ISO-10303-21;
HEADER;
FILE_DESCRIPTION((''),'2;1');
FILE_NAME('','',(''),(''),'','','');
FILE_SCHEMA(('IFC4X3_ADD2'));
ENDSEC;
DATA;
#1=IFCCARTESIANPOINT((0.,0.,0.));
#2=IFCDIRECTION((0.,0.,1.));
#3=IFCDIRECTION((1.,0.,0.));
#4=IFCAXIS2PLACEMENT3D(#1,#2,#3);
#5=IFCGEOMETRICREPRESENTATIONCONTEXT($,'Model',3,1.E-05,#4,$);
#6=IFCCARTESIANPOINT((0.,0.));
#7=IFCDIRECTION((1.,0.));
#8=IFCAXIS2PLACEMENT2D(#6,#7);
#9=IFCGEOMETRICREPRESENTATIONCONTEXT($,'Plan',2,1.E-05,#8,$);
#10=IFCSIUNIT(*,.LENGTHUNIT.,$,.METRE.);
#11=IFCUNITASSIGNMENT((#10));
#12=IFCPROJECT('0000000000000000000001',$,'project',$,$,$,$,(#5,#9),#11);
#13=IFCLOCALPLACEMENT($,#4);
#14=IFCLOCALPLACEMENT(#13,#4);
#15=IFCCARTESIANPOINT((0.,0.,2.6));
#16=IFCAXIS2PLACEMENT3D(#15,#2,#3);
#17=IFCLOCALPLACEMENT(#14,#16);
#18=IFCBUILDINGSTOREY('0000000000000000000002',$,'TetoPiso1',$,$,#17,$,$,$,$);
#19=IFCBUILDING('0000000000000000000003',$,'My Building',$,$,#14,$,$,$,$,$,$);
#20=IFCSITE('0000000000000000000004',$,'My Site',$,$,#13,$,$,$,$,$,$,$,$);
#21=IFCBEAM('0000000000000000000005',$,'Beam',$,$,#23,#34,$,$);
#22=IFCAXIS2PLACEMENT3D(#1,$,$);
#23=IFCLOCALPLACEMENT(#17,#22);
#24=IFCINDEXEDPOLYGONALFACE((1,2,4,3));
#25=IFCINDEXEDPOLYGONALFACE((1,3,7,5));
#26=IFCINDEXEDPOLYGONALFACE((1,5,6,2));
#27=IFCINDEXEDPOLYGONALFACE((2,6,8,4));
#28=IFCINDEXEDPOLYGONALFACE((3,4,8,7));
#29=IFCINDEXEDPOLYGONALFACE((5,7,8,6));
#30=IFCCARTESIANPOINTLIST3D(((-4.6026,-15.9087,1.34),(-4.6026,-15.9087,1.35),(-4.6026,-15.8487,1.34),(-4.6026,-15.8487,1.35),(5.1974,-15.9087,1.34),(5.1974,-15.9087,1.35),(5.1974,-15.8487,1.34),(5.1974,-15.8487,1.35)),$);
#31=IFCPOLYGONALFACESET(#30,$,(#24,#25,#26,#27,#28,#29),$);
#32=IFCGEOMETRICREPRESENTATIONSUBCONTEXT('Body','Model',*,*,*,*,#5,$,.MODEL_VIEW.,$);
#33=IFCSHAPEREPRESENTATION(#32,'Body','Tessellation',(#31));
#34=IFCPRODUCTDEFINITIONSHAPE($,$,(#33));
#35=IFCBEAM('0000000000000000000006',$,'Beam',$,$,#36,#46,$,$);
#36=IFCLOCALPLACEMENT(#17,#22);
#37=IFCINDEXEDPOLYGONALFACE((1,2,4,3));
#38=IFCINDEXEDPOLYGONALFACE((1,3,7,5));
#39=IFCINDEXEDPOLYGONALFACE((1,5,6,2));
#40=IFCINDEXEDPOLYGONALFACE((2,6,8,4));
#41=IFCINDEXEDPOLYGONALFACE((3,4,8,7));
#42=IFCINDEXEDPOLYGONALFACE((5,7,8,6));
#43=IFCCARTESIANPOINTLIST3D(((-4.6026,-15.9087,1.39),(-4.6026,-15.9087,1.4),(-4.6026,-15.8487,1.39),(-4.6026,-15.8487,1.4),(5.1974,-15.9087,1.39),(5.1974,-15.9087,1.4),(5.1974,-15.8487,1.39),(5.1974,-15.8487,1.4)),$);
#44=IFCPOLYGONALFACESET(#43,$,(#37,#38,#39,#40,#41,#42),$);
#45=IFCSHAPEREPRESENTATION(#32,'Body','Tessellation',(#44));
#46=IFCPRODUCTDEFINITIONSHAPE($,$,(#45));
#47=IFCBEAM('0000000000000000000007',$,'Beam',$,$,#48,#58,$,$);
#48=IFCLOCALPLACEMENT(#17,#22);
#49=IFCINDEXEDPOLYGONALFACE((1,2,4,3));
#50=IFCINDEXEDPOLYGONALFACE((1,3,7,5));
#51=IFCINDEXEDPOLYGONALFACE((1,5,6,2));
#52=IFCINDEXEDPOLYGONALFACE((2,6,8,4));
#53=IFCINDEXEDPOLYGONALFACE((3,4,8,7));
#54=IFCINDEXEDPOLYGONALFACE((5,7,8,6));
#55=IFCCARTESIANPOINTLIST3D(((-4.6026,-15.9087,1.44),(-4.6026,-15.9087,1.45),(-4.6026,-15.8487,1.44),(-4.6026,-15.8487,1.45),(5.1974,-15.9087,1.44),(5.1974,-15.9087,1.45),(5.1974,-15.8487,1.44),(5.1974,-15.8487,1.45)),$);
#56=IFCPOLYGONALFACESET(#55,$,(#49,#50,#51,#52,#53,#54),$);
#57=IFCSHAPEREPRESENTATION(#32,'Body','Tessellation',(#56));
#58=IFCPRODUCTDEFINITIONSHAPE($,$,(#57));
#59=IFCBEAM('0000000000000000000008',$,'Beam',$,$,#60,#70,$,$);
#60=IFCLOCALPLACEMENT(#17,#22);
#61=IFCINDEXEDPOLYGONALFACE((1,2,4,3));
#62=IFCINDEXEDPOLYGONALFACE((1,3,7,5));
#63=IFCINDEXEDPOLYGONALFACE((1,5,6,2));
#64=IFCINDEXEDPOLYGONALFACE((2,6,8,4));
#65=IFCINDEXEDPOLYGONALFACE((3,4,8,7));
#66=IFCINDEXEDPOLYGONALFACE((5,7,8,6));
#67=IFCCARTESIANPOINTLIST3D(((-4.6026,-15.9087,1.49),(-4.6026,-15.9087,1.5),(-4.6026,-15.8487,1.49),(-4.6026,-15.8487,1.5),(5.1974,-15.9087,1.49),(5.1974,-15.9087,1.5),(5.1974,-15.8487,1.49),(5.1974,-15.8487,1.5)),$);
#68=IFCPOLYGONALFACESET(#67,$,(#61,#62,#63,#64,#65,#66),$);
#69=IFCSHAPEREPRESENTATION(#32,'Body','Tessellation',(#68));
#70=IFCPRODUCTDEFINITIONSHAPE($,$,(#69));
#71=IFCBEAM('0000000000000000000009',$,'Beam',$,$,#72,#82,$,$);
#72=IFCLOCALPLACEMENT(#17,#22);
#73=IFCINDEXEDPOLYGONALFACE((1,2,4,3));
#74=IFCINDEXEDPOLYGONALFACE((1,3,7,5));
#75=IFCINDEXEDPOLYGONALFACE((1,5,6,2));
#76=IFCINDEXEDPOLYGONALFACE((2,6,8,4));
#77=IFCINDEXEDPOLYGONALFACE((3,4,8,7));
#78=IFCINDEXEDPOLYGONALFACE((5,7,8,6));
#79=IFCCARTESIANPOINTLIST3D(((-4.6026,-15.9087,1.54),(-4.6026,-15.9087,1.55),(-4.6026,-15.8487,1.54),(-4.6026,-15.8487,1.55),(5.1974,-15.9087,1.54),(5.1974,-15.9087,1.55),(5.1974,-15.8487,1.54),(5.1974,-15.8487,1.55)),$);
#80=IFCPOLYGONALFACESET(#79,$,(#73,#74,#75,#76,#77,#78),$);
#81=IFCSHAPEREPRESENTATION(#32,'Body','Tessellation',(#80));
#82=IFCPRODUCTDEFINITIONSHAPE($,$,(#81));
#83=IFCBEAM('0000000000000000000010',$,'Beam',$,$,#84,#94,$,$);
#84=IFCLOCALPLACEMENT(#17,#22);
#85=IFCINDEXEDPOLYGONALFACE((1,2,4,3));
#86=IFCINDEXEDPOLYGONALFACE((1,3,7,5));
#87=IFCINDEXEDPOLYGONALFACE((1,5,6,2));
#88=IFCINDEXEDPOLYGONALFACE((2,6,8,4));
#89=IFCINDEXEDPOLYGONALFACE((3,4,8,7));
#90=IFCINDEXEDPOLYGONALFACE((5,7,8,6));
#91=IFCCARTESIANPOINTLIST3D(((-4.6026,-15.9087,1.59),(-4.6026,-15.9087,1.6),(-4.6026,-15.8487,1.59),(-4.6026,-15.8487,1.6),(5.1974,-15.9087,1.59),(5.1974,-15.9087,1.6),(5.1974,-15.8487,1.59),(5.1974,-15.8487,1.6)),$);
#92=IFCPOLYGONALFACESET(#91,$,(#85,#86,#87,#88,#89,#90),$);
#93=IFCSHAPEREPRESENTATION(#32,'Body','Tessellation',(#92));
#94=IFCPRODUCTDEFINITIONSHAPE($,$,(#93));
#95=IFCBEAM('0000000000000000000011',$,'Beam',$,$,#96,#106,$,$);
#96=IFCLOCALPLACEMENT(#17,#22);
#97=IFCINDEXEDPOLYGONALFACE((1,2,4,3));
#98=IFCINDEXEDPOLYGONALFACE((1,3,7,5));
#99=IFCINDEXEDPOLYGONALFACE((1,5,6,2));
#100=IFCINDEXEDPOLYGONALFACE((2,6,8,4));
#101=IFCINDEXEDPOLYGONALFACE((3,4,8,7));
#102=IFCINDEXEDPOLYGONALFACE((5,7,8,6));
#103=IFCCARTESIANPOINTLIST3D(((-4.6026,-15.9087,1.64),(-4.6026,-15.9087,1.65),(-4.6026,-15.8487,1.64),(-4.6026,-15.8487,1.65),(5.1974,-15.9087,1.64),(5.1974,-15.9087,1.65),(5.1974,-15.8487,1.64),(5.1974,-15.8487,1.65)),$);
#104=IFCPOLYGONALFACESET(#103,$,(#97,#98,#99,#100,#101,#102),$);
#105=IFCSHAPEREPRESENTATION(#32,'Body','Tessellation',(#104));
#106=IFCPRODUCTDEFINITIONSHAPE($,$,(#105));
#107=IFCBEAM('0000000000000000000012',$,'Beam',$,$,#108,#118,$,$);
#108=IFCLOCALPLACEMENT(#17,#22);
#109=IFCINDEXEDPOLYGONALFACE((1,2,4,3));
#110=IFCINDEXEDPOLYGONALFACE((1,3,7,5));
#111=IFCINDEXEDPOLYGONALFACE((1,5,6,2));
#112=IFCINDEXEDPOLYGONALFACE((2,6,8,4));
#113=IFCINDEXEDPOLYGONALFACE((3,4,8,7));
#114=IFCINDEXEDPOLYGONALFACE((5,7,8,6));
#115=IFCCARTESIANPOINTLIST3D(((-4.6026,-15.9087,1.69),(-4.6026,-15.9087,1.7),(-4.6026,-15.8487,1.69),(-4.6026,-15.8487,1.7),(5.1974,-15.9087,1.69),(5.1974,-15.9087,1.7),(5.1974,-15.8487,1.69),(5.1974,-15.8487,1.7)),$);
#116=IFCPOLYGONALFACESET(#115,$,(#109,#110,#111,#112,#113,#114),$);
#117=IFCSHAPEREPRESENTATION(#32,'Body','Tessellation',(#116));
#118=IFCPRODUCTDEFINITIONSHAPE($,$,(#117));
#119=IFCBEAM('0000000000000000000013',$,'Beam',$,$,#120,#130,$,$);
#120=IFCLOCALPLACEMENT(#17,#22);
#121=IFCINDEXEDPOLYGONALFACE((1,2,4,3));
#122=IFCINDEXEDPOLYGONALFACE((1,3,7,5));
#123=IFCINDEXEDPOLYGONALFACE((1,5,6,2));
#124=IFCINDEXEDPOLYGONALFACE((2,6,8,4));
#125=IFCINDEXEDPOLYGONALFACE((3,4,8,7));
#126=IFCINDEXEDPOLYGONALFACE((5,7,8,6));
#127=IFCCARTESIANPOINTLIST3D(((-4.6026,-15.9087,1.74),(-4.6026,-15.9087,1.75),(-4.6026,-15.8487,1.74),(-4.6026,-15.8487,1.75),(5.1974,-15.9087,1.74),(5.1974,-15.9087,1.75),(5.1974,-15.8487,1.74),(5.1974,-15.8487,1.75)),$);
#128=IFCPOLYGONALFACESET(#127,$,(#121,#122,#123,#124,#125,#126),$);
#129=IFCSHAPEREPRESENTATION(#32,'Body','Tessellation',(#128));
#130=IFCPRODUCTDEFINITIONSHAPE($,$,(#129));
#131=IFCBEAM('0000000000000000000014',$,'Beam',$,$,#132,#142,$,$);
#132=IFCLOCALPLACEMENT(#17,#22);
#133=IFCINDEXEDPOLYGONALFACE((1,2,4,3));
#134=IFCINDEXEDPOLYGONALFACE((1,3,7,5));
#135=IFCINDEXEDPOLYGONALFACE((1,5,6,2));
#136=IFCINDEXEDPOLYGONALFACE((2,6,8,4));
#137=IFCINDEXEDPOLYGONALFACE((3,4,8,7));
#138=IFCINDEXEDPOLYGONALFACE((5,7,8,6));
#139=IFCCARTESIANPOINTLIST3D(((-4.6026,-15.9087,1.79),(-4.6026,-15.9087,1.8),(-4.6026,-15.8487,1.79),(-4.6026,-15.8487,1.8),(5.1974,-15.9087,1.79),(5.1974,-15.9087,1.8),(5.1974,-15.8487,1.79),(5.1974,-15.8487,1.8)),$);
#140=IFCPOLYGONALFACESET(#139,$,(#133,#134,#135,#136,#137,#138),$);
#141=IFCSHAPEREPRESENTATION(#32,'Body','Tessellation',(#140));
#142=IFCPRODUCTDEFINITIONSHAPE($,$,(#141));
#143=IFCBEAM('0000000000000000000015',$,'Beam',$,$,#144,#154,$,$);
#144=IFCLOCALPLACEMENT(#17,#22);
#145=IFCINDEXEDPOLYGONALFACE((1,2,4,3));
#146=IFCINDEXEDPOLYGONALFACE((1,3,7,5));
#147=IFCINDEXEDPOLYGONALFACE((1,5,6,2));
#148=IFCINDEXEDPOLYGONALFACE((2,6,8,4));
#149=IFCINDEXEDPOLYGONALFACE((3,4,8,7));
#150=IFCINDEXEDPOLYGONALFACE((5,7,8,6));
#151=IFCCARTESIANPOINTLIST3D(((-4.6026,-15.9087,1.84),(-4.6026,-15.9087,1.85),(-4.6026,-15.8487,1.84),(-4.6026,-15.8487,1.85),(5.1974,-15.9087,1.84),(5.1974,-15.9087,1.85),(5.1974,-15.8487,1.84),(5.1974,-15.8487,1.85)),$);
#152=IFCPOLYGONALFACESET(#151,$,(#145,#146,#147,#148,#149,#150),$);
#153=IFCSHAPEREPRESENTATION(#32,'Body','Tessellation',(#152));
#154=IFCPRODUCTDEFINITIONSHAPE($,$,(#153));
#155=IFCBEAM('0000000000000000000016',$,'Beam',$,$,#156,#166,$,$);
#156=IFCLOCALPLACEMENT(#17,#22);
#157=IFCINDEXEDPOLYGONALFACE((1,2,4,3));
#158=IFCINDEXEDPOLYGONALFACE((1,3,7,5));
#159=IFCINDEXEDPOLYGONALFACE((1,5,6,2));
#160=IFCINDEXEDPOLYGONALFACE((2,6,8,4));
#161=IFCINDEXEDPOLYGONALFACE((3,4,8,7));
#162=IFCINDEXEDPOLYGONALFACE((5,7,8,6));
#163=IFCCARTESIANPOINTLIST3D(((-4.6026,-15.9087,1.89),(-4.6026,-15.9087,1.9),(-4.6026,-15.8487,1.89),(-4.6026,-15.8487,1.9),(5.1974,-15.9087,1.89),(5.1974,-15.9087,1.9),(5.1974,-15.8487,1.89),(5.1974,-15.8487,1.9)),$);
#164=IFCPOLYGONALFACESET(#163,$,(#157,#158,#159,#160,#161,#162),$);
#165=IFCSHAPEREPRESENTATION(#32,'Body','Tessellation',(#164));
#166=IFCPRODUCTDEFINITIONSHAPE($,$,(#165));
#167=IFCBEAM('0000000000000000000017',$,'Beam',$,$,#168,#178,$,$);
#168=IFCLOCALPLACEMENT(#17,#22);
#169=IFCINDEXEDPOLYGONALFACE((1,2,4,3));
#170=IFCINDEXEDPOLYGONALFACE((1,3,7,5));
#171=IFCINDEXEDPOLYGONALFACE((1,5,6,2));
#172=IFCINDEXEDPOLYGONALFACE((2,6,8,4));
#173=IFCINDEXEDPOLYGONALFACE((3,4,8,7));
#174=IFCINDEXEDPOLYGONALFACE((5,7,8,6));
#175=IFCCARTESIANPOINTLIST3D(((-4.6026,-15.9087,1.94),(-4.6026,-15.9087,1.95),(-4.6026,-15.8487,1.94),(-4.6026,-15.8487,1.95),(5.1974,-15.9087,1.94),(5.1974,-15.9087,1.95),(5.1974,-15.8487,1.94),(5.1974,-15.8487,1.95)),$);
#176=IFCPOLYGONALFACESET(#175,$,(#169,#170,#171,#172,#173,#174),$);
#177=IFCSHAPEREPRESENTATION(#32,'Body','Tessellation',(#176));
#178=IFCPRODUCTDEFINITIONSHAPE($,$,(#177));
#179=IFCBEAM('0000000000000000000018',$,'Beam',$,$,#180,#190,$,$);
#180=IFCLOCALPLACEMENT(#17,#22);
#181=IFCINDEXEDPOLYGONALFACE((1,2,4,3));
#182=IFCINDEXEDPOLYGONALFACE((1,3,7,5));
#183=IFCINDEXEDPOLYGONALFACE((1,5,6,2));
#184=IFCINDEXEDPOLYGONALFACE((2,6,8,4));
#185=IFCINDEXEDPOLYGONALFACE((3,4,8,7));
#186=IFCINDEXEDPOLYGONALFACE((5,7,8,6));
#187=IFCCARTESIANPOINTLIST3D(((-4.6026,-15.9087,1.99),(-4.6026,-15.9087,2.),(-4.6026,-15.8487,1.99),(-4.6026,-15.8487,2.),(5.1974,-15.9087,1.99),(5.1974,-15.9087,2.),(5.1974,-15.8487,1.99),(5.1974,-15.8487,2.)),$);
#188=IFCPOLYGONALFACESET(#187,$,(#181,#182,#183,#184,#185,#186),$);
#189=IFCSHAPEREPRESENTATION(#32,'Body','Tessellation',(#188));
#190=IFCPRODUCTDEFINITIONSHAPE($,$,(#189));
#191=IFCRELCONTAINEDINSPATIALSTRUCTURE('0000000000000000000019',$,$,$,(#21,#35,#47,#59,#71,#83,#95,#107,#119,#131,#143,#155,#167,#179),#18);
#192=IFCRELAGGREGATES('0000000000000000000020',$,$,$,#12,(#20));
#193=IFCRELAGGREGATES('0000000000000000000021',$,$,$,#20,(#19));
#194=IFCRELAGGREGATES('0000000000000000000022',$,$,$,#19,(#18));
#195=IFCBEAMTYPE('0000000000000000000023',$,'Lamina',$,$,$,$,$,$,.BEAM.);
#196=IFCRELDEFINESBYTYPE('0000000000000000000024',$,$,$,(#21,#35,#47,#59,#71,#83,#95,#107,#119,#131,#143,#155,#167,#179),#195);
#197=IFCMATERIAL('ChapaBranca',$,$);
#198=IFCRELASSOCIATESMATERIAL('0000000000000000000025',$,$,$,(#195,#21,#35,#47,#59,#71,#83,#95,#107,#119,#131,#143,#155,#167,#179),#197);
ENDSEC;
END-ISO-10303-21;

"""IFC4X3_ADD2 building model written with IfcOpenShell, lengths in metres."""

from ifc_helpers import new_model, si_unit, frame, origin_with_axes, origin_2d, origin_2d_with_axis, place, context, subcontext, project, spatial, rectangle, extrude, material, material_profile, profile_set, profile_usage, type_object, element, save


model = new_model("IFC4X3_ADD2")

# Units and contexts
model_context = context("Model", 3, precision=1e-05, world=origin_with_axes())
plan_context = context("Plan", 2, precision=1e-05, world=origin_2d_with_axis())
body_context = subcontext(model_context, "Body", "Model", "MODEL_VIEW")
ifc_project = project(units=[si_unit("LENGTHUNIT", "METRE")], contexts=[model_context, plan_context])

# Site, building, storey
site_placement = place(None, origin_with_axes())
site = spatial("IfcSite", under=ifc_project, at=site_placement, Name="My Site")
building_placement = place(site_placement, origin_with_axes())
building = spatial("IfcBuilding", under=site, at=building_placement, Name="My Building")
storey_placement = place(building_placement, frame((0.0, 0.0, 2.6), z_axis=(0.0, 0.0, 1.0), x_axis=(1.0, 0.0, 0.0)))
storey = spatial("IfcBuildingStorey", under=building, at=storey_placement, Name="TetoPiso1")

# Beams
ifc_material = material(Name="ChapaBranca")
ifc_material_profile = material_profile(ifc_material, rectangle(XDim=0.06, YDim=0.01, at=origin_2d()))
ifc_profile_set = profile_set([ifc_material_profile])
ifc_profile_usage_1 = profile_usage(ifc_profile_set, cardinal=5)
beam_type = type_object("IfcBeamType", Name="Lamina", PredefinedType="BEAM", material=ifc_profile_set)
beam_1_placement = place(storey_placement, frame((-4.6026, -15.8787, 1.345), z_axis=(1.0, 0.0, 0.0), x_axis=(0.0, 1.0, 0.0)))
element("IfcBeam", 1, at=beam_1_placement, inside=storey, type_object=beam_type, material=ifc_profile_usage_1, Name="Beam", context=body_context, shape_type="SweptSolid", body=[
    extrude(rectangle(XDim=0.06, YDim=0.01, at=origin_2d()), origin_with_axes(), (0.0, 0.0, 1.0), 9.8),
])
ifc_profile_usage_2 = profile_usage(ifc_profile_set, cardinal=5)
beam_2_placement = place(storey_placement, frame((-4.6026, -15.8787, 1.395), z_axis=(1.0, 0.0, 0.0), x_axis=(0.0, 1.0, 0.0)))
element("IfcBeam", 2, at=beam_2_placement, inside=storey, type_object=beam_type, material=ifc_profile_usage_2, Name="Beam", context=body_context, shape_type="SweptSolid", body=[
    extrude(rectangle(XDim=0.06, YDim=0.01, at=origin_2d()), origin_with_axes(), (0.0, 0.0, 1.0), 9.8),
])
ifc_profile_usage_3 = profile_usage(ifc_profile_set, cardinal=5)
beam_3_placement = place(storey_placement, frame((-4.6026, -15.8787, 1.445), z_axis=(1.0, 0.0, 0.0), x_axis=(0.0, 1.0, 0.0)))
element("IfcBeam", 3, at=beam_3_placement, inside=storey, type_object=beam_type, material=ifc_profile_usage_3, Name="Beam", context=body_context, shape_type="SweptSolid", body=[
    extrude(rectangle(XDim=0.06, YDim=0.01, at=origin_2d()), origin_with_axes(), (0.0, 0.0, 1.0), 9.8),
])
ifc_profile_usage_4 = profile_usage(ifc_profile_set, cardinal=5)
beam_4_placement = place(storey_placement, frame((-4.6026, -15.8787, 1.495), z_axis=(1.0, 0.0, 0.0), x_axis=(0.0, 1.0, 0.0)))
element("IfcBeam", 4, at=beam_4_placement, inside=storey, type_object=beam_type, material=ifc_profile_usage_4, Name="Beam", context=body_context, shape_type="SweptSolid", body=[
    extrude(rectangle(XDim=0.06, YDim=0.01, at=origin_2d()), origin_with_axes(), (0.0, 0.0, 1.0), 9.8),
])
ifc_profile_usage_5 = profile_usage(ifc_profile_set, cardinal=5)
beam_5_placement = place(storey_placement, frame((-4.6026, -15.8787, 1.545), z_axis=(1.0, 0.0, 0.0), x_axis=(0.0, 1.0, 0.0)))
element("IfcBeam", 5, at=beam_5_placement, inside=storey, type_object=beam_type, material=ifc_profile_usage_5, Name="Beam", context=body_context, shape_type="SweptSolid", body=[
    extrude(rectangle(XDim=0.06, YDim=0.01, at=origin_2d()), origin_with_axes(), (0.0, 0.0, 1.0), 9.8),
])
ifc_profile_usage_6 = profile_usage(ifc_profile_set, cardinal=5)
beam_6_placement = place(storey_placement, frame((-4.6026, -15.8787, 1.595), z_axis=(1.0, 0.0, 0.0), x_axis=(0.0, 1.0, 0.0)))
element("IfcBeam", 6, at=beam_6_placement, inside=storey, type_object=beam_type, material=ifc_profile_usage_6, Name="Beam", context=body_context, shape_type="SweptSolid", body=[
    extrude(rectangle(XDim=0.06, YDim=0.01, at=origin_2d()), origin_with_axes(), (0.0, 0.0, 1.0), 9.8),
])
ifc_profile_usage_7 = profile_usage(ifc_profile_set, cardinal=5)
beam_7_placement = place(storey_placement, frame((-4.6026, -15.8787, 1.645), z_axis=(1.0, 0.0, 0.0), x_axis=(0.0, 1.0, 0.0)))
element("IfcBeam", 7, at=beam_7_placement, inside=storey, type_object=beam_type, material=ifc_profile_usage_7, Name="Beam", context=body_context, shape_type="SweptSolid", body=[
    extrude(rectangle(XDim=0.06, YDim=0.01, at=origin_2d()), origin_with_axes(), (0.0, 0.0, 1.0), 9.8),
])
ifc_profile_usage_8 = profile_usage(ifc_profile_set, cardinal=5)
beam_8_placement = place(storey_placement, frame((-4.6026, -15.8787, 1.695), z_axis=(1.0, 0.0, 0.0), x_axis=(0.0, 1.0, 0.0)))
element("IfcBeam", 8, at=beam_8_placement, inside=storey, type_object=beam_type, material=ifc_profile_usage_8, Name="Beam", context=body_context, shape_type="SweptSolid", body=[
    extrude(rectangle(XDim=0.06, YDim=0.01, at=origin_2d()), origin_with_axes(), (0.0, 0.0, 1.0), 9.8),
])
ifc_profile_usage_9 = profile_usage(ifc_profile_set, cardinal=5)
beam_9_placement = place(storey_placement, frame((-4.6026, -15.8787, 1.745), z_axis=(1.0, 0.0, 0.0), x_axis=(0.0, 1.0, 0.0)))
element("IfcBeam", 9, at=beam_9_placement, inside=storey, type_object=beam_type, material=ifc_profile_usage_9, Name="Beam", context=body_context, shape_type="SweptSolid", body=[
    extrude(rectangle(XDim=0.06, YDim=0.01, at=origin_2d()), origin_with_axes(), (0.0, 0.0, 1.0), 9.8),
])
ifc_profile_usage_10 = profile_usage(ifc_profile_set, cardinal=5)
beam_10_placement = place(storey_placement, frame((-4.6026, -15.8787, 1.795), z_axis=(1.0, 0.0, 0.0), x_axis=(0.0, 1.0, 0.0)))
element("IfcBeam", 10, at=beam_10_placement, inside=storey, type_object=beam_type, material=ifc_profile_usage_10, Name="Beam", context=body_context, shape_type="SweptSolid", body=[
    extrude(rectangle(XDim=0.06, YDim=0.01, at=origin_2d()), origin_with_axes(), (0.0, 0.0, 1.0), 9.8),
])
ifc_profile_usage_11 = profile_usage(ifc_profile_set, cardinal=5)
beam_11_placement = place(storey_placement, frame((-4.6026, -15.8787, 1.845), z_axis=(1.0, 0.0, 0.0), x_axis=(0.0, 1.0, 0.0)))
element("IfcBeam", 11, at=beam_11_placement, inside=storey, type_object=beam_type, material=ifc_profile_usage_11, Name="Beam", context=body_context, shape_type="SweptSolid", body=[
    extrude(rectangle(XDim=0.06, YDim=0.01, at=origin_2d()), origin_with_axes(), (0.0, 0.0, 1.0), 9.8),
])
ifc_profile_usage_12 = profile_usage(ifc_profile_set, cardinal=5)
beam_12_placement = place(storey_placement, frame((-4.6026, -15.8787, 1.895), z_axis=(1.0, 0.0, 0.0), x_axis=(0.0, 1.0, 0.0)))
element("IfcBeam", 12, at=beam_12_placement, inside=storey, type_object=beam_type, material=ifc_profile_usage_12, Name="Beam", context=body_context, shape_type="SweptSolid", body=[
    extrude(rectangle(XDim=0.06, YDim=0.01, at=origin_2d()), origin_with_axes(), (0.0, 0.0, 1.0), 9.8),
])
ifc_profile_usage_13 = profile_usage(ifc_profile_set, cardinal=5)
beam_13_placement = place(storey_placement, frame((-4.6026, -15.8787, 1.945), z_axis=(1.0, 0.0, 0.0), x_axis=(0.0, 1.0, 0.0)))
element("IfcBeam", 13, at=beam_13_placement, inside=storey, type_object=beam_type, material=ifc_profile_usage_13, Name="Beam", context=body_context, shape_type="SweptSolid", body=[
    extrude(rectangle(XDim=0.06, YDim=0.01, at=origin_2d()), origin_with_axes(), (0.0, 0.0, 1.0), 9.8),
])
ifc_profile_usage_14 = profile_usage(ifc_profile_set, cardinal=5)
beam_14_placement = place(storey_placement, frame((-4.6026, -15.8787, 1.995), z_axis=(1.0, 0.0, 0.0), x_axis=(0.0, 1.0, 0.0)))
element("IfcBeam", 14, at=beam_14_placement, inside=storey, type_object=beam_type, material=ifc_profile_usage_14, Name="Beam", context=body_context, shape_type="SweptSolid", body=[
    extrude(rectangle(XDim=0.06, YDim=0.01, at=origin_2d()), origin_with_axes(), (0.0, 0.0, 1.0), 9.8),
])

save(model, "model.ifc")
